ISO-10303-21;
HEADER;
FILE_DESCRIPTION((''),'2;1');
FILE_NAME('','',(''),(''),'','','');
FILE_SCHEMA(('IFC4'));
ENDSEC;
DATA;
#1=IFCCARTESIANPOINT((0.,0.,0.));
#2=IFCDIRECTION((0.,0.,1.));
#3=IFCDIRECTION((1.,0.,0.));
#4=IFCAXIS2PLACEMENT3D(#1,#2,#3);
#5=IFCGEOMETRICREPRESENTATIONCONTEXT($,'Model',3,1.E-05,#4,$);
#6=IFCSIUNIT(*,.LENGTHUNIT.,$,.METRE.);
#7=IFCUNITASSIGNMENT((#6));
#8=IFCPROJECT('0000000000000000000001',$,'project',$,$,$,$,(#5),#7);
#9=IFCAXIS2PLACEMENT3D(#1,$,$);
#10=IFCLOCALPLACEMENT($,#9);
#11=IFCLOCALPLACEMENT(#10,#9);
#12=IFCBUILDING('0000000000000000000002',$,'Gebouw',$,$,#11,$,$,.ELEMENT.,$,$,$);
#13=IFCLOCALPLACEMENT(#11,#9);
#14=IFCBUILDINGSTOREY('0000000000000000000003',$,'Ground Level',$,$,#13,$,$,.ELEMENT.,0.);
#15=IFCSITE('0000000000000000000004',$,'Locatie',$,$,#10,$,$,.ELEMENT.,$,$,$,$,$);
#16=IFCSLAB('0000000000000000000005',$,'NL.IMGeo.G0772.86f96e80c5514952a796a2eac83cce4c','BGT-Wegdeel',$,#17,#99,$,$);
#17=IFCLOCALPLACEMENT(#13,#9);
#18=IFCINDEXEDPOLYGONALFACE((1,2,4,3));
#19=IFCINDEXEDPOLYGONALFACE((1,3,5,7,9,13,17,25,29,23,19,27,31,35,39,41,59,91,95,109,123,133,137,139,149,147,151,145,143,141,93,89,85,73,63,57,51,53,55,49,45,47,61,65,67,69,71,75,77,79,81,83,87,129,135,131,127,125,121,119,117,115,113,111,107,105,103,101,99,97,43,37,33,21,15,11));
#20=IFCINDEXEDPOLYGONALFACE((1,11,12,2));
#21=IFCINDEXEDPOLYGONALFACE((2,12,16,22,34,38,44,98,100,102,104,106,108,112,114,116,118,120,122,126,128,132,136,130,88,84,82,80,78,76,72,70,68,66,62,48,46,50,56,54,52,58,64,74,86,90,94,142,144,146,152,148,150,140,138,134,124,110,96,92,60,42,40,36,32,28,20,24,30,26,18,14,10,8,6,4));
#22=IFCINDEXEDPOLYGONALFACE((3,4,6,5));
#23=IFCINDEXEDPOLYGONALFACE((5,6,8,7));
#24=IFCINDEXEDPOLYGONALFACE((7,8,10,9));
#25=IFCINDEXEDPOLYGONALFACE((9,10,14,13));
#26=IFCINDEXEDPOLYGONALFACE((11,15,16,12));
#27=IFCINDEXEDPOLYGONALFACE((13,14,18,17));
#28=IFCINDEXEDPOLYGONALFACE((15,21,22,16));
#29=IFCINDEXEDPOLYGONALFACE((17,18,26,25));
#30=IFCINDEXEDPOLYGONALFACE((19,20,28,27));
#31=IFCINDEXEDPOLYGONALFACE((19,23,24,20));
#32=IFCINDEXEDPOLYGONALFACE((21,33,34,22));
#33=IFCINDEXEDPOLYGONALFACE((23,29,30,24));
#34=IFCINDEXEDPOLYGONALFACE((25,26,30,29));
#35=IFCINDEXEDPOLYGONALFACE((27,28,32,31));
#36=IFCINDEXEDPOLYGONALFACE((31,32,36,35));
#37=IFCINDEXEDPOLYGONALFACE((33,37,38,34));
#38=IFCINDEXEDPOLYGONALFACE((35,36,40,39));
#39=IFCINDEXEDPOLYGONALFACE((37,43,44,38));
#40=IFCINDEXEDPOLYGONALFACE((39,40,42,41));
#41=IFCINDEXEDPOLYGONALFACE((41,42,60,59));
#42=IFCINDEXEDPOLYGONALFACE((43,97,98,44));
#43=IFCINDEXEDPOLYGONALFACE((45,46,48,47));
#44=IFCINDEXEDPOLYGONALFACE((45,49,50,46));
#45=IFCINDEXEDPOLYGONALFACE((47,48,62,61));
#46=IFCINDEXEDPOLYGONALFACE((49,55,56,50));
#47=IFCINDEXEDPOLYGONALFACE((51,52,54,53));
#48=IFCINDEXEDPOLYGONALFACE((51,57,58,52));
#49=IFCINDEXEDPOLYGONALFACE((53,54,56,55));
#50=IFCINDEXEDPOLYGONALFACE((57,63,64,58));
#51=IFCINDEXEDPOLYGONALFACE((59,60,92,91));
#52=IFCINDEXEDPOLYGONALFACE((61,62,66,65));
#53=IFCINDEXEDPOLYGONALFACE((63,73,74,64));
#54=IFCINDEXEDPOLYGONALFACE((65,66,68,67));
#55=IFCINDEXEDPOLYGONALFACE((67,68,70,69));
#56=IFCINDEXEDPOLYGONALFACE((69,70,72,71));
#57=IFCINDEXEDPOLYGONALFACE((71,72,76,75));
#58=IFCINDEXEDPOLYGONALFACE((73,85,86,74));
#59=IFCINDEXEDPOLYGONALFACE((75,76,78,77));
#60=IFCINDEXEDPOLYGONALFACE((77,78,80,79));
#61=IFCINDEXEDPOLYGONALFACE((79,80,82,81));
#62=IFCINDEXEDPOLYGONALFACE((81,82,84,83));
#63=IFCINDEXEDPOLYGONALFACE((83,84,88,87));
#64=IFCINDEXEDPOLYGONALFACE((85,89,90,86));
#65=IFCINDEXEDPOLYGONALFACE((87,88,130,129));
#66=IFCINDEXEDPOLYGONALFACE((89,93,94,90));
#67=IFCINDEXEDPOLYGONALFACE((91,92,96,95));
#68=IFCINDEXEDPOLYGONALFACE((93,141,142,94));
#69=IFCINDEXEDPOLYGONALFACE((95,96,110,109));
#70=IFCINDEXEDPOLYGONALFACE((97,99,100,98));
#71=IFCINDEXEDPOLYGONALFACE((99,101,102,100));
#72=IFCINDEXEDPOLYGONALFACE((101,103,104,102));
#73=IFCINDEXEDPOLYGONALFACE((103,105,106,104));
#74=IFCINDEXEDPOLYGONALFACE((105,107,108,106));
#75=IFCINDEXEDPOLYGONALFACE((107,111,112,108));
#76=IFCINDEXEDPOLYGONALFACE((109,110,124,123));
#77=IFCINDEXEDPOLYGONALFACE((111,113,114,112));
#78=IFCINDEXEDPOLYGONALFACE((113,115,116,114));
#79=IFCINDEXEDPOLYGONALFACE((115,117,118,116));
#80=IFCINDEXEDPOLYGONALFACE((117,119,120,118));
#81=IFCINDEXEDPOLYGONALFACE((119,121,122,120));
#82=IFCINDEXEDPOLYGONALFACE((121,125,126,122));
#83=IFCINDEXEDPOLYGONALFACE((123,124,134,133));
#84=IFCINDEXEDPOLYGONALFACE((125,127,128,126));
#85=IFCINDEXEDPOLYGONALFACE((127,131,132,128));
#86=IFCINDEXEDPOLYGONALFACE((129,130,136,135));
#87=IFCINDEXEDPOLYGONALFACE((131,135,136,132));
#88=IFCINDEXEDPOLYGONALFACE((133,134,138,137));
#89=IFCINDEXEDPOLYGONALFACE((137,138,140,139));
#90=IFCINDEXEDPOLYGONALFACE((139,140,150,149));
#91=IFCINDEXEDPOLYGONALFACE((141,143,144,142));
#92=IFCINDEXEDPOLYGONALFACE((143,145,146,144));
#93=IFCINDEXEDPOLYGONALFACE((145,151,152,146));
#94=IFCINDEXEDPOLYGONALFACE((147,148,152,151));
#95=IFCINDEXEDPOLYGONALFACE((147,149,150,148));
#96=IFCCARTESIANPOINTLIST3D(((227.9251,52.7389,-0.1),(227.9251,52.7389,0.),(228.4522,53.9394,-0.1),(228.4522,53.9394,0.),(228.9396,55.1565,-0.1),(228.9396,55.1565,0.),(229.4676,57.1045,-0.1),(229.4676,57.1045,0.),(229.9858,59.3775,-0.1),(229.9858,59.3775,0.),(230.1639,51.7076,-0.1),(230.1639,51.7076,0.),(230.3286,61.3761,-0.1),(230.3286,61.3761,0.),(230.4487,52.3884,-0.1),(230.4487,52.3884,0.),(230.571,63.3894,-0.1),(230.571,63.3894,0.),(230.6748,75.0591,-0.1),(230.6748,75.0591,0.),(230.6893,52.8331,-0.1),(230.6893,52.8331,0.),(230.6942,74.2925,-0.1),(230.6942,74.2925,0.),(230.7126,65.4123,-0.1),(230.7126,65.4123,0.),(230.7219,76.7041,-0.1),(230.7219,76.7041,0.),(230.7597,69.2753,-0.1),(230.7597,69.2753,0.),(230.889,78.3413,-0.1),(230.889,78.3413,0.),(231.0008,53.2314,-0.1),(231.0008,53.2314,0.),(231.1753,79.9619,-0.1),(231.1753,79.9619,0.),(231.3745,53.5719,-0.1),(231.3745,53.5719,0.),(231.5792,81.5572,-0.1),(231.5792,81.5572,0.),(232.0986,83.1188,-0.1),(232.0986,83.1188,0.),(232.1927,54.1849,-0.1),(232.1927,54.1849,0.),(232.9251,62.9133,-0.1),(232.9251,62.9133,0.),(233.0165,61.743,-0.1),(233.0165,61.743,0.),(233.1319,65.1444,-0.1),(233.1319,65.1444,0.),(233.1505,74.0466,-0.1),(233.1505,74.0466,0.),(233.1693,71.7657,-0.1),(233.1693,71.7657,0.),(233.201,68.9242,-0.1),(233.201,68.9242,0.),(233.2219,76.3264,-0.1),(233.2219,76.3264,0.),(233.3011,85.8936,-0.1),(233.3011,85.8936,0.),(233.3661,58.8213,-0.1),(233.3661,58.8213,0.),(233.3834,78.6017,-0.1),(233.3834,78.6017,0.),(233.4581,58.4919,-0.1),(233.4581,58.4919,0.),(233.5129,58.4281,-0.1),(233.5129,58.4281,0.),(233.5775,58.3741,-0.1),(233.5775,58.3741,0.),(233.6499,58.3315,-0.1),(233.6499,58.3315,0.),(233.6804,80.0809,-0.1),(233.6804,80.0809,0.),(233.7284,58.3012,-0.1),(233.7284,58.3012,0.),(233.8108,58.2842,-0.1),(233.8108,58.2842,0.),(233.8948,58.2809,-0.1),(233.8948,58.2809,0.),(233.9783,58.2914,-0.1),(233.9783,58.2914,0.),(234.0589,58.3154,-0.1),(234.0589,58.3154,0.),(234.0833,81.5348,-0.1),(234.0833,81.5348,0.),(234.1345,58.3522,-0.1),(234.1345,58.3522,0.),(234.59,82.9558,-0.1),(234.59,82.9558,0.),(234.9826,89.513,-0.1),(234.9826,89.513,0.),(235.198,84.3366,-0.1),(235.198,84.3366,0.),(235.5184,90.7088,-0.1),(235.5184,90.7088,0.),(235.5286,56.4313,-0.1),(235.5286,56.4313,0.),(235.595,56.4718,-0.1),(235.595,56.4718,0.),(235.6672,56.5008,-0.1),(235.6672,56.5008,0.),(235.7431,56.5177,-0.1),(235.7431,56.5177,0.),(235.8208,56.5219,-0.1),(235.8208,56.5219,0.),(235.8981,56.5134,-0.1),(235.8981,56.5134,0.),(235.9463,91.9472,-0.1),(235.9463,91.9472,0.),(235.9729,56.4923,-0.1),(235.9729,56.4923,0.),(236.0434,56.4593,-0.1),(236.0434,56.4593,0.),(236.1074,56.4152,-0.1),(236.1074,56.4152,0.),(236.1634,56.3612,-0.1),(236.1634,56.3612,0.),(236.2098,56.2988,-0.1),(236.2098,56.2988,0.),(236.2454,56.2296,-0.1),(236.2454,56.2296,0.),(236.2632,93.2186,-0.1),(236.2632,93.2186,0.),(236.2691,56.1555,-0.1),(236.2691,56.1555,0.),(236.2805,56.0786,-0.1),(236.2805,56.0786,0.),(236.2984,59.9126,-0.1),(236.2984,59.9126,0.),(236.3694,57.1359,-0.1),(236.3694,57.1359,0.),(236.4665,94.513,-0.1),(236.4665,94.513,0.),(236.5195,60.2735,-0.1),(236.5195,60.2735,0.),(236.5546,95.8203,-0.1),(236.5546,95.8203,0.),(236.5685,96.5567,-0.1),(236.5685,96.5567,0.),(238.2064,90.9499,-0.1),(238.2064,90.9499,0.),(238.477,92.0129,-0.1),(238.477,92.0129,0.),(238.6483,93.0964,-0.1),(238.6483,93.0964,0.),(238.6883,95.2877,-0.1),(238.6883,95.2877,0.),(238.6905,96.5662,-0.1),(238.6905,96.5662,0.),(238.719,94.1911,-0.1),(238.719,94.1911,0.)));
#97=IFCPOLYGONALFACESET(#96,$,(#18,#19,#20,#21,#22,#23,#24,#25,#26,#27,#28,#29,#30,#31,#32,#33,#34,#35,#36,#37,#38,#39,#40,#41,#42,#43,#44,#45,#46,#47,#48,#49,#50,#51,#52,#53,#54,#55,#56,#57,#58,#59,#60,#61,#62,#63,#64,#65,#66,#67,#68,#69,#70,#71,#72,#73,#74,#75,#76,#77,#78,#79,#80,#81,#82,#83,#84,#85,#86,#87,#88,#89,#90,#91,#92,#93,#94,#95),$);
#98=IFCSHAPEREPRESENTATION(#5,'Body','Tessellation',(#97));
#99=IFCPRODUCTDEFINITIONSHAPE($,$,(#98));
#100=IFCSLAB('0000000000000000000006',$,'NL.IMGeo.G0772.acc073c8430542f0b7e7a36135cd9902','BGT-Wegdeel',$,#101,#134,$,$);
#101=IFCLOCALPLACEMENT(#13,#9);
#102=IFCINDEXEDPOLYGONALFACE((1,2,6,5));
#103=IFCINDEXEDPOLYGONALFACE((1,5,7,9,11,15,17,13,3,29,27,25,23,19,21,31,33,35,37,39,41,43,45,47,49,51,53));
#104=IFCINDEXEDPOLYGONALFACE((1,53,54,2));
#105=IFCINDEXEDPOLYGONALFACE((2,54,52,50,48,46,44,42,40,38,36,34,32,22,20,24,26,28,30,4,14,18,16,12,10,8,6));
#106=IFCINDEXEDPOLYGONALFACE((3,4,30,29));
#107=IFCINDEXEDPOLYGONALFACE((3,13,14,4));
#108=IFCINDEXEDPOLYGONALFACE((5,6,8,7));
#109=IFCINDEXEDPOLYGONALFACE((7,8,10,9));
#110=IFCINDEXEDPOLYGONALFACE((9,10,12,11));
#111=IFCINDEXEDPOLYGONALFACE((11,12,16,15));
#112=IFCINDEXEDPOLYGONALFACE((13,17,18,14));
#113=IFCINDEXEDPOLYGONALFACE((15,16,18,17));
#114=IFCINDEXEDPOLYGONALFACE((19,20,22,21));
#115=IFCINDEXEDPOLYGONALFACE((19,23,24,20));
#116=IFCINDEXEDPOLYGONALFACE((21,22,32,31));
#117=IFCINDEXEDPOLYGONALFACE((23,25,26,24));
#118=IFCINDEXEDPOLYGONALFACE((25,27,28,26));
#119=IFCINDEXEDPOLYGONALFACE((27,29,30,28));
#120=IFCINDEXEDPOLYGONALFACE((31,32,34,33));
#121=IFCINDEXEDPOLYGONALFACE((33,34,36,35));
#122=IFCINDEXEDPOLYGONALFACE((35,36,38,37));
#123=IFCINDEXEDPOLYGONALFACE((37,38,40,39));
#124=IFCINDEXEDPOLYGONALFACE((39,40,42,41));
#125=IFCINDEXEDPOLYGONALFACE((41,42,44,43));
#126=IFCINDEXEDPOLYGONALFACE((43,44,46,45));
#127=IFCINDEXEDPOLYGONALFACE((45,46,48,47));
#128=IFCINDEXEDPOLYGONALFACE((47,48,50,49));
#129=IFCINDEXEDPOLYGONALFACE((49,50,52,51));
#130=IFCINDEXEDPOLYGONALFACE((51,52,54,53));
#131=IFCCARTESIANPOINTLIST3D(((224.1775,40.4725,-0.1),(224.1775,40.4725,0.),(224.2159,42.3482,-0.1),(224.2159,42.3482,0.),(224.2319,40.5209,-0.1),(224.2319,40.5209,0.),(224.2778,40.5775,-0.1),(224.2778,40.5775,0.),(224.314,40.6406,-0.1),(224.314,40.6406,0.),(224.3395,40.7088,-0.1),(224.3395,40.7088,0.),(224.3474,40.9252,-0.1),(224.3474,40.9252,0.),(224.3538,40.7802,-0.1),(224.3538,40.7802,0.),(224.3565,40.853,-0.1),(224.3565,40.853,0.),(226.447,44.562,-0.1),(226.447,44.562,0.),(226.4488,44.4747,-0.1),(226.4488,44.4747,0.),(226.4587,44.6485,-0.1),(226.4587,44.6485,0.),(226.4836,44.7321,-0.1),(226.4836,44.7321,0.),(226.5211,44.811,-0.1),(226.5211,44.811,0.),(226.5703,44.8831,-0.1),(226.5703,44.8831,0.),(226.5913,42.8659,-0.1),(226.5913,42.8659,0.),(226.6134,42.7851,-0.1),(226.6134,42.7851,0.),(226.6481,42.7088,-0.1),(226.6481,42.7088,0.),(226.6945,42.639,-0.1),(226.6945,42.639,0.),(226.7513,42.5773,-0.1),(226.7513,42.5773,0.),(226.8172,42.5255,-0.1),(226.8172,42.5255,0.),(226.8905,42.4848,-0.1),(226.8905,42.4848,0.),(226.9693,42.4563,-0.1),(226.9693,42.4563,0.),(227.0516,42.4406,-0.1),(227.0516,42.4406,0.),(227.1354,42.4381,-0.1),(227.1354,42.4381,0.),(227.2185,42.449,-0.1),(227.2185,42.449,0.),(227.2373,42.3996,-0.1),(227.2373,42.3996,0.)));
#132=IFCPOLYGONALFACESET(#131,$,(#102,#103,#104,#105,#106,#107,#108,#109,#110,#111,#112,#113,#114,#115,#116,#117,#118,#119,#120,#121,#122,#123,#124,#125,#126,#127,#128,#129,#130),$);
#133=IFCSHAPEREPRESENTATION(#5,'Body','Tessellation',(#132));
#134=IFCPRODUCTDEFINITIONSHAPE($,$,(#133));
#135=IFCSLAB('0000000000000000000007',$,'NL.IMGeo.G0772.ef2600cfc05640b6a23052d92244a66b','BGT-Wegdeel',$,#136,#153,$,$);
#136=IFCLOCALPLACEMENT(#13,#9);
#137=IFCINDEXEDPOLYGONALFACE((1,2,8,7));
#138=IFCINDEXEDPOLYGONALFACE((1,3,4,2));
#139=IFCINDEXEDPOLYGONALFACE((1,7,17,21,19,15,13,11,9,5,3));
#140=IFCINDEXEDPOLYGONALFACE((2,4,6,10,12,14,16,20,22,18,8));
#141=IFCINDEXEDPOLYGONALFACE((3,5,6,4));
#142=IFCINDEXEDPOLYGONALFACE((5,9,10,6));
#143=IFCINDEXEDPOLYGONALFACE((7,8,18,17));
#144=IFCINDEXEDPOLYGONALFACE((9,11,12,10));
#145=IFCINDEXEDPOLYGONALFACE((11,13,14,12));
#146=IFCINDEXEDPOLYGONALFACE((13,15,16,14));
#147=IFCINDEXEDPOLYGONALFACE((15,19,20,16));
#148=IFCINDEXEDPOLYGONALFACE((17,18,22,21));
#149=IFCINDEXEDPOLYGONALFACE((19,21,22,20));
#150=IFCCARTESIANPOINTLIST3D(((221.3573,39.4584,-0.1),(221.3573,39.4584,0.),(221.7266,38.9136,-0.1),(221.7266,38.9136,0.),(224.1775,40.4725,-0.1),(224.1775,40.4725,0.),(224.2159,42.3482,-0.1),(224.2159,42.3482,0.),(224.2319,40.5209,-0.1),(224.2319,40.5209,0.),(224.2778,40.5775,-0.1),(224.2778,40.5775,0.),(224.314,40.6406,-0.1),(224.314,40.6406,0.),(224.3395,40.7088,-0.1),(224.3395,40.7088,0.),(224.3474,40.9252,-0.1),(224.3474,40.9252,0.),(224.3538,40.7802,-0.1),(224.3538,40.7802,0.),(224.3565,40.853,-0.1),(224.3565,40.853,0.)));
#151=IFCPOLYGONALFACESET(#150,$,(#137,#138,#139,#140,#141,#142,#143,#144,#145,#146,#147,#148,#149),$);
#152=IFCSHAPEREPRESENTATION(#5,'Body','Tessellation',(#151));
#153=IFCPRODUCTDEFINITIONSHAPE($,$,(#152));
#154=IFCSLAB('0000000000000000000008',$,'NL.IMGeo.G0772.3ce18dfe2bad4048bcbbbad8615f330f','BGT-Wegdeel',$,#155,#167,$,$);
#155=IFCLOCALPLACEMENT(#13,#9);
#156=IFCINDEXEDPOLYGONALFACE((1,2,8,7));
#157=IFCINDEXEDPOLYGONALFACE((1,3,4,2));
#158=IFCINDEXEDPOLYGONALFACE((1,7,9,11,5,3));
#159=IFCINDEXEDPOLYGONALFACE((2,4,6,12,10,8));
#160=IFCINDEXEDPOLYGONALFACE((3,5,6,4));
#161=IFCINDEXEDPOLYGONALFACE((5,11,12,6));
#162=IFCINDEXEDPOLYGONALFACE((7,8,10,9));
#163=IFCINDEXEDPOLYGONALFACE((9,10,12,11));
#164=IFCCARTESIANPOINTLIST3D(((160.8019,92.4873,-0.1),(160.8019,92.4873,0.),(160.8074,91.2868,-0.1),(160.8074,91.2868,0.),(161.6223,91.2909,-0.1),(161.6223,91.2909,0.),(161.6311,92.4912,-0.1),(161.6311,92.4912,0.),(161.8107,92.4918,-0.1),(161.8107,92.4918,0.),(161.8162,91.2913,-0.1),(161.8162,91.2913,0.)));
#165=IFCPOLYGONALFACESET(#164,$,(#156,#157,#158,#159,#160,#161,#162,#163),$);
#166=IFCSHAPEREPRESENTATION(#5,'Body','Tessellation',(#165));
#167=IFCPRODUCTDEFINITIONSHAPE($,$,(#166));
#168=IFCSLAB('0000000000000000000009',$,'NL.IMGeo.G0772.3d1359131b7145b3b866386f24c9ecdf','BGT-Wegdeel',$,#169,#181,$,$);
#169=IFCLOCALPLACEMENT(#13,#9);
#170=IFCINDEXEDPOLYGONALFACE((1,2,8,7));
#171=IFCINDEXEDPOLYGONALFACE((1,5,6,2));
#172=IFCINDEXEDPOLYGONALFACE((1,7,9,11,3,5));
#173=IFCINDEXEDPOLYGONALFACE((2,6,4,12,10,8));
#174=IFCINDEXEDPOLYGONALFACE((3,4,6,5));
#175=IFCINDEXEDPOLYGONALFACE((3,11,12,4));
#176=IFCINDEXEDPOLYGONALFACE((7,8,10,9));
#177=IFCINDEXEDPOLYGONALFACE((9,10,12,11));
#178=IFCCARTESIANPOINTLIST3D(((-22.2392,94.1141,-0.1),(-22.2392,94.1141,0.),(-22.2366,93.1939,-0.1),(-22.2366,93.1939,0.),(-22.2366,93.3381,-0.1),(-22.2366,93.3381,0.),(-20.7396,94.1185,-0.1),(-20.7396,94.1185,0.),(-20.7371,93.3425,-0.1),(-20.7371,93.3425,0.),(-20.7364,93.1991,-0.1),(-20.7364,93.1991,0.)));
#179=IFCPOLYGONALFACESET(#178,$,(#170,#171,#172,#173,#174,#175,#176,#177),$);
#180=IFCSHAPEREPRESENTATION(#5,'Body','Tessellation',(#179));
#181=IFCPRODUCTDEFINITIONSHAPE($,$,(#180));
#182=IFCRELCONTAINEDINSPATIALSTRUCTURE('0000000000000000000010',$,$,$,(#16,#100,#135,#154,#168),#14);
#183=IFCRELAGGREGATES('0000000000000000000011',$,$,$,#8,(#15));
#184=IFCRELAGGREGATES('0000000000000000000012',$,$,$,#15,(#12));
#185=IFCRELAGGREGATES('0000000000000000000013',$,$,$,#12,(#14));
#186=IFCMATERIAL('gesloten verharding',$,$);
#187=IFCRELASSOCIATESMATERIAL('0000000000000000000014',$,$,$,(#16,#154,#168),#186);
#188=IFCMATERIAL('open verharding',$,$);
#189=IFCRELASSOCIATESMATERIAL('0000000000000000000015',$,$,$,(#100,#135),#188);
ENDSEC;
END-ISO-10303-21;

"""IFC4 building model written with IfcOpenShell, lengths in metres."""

from ifc_helpers import new_model, si_unit, frame, origin, origin_with_axes, place, context, project, spatial, polyline, outline, extrude, material, element, save


model = new_model("IFC4")

# Units and contexts
model_context = context("Model", 3, precision=1e-05, world=origin_with_axes())
ifc_project = project(units=[si_unit("LENGTHUNIT", "METRE")], contexts=[model_context])

# Site, building, storey
site_placement = place(None, origin())
site = spatial("IfcSite", under=ifc_project, at=site_placement, Name="Locatie", CompositionType="ELEMENT")
building_placement = place(site_placement, origin())
building = spatial("IfcBuilding", under=site, at=building_placement, Name="Gebouw", CompositionType="ELEMENT")
storey_placement = place(building_placement, origin())
storey = spatial("IfcBuildingStorey", under=building, at=storey_placement, Name="Ground Level", CompositionType="ELEMENT", Elevation=0.0)

# Slabs
ifc_material_1 = material(Name="open verharding")
ifc_material_2 = material(Name="gesloten verharding")
slab_1_placement = place(storey_placement, origin())
element("IfcSlab", 1, at=slab_1_placement, inside=storey, material=ifc_material_2, Name="NL.IMGeo.G0772.86f96e80c5514952a796a2eac83cce4c", Description="BGT-Wegdeel", context=model_context, shape_type="SweptSolid", body=[
    extrude(outline(polyline([(233.3661, 58.8213), (233.4581, 58.4919), (233.5129, 58.4281), (233.5775, 58.3741), (233.6499, 58.3315), (233.7284, 58.3012), (233.8108, 58.2842), (233.8948, 58.2809), (233.9783, 58.2914), (234.0589, 58.3154), (234.1345, 58.3522), (236.2984, 59.9126), (236.5195, 60.2735), (236.3694, 57.1359), (236.2805, 56.0786), (236.2691, 56.1555), (236.2454, 56.2296), (236.2098, 56.2988), (236.1634, 56.3612), (236.1074, 56.4152), (236.0434, 56.4593), (235.9729, 56.4923), (235.8981, 56.5134), (235.8208, 56.5219), (235.7431, 56.5177), (235.6672, 56.5008), (235.595, 56.4718), (235.5286, 56.4313), (232.1927, 54.1849), (231.3745, 53.5719), (231.0008, 53.2314), (230.6893, 52.8331), (230.4487, 52.3884), (230.1639, 51.7076), (227.9251, 52.7389), (228.4522, 53.9394), (228.9396, 55.1565), (229.4676, 57.1045), (229.9858, 59.3775), (230.3286, 61.3761), (230.571, 63.3894), (230.7126, 65.4123), (230.7597, 69.2753), (230.6942, 74.2925), (230.6748, 75.0591), (230.7219, 76.7041), (230.889, 78.3413), (231.1753, 79.9619), (231.5792, 81.5572), (232.0986, 83.1188), (233.3011, 85.8936), (234.9826, 89.513), (235.5184, 90.7088), (235.9463, 91.9472), (236.2632, 93.2186), (236.4665, 94.513), (236.5546, 95.8203), (236.5685, 96.5567), (238.6905, 96.5662), (238.6883, 95.2877), (238.719, 94.1911), (238.6483, 93.0964), (238.477, 92.0129), (238.2064, 90.9499), (235.198, 84.3366), (234.59, 82.9558), (234.0833, 81.5348), (233.6804, 80.0809), (233.3834, 78.6017), (233.2219, 76.3264), (233.1505, 74.0466), (233.1693, 71.7657), (233.201, 68.9242), (233.1319, 65.1444), (232.9251, 62.9133), (233.0165, 61.743), (233.3661, 58.8213)])), frame((0.0, 0.0, -0.1), z_axis=(0.0, 0.0, 1.0), x_axis=(1.0, 0.0, 0.0)), (0.0, 0.0, 1.0), 0.1),
])
slab_2_placement = place(storey_placement, origin())
element("IfcSlab", 2, at=slab_2_placement, inside=storey, material=ifc_material_1, Name="NL.IMGeo.G0772.acc073c8430542f0b7e7a36135cd9902", Description="BGT-Wegdeel", context=model_context, shape_type="SweptSolid", body=[
    extrude(outline(polyline([(226.5211, 44.811), (226.4836, 44.7321), (226.4587, 44.6485), (226.447, 44.562), (226.4488, 44.4747), (226.5913, 42.8659), (226.6134, 42.7851), (226.6481, 42.7088), (226.6945, 42.639), (226.7513, 42.5773), (226.8172, 42.5255), (226.8905, 42.4848), (226.9693, 42.4563), (227.0516, 42.4406), (227.1354, 42.4381), (227.2185, 42.449), (227.2373, 42.3996), (224.1775, 40.4725), (224.2319, 40.5209), (224.2778, 40.5775), (224.314, 40.6406), (224.3395, 40.7088), (224.3538, 40.7802), (224.3565, 40.853), (224.3474, 40.9252), (224.2159, 42.3482), (226.5703, 44.8831), (226.5211, 44.811)])), frame((0.0, 0.0, -0.1), z_axis=(0.0, 0.0, 1.0), x_axis=(1.0, 0.0, 0.0)), (0.0, 0.0, 1.0), 0.1),
])
slab_3_placement = place(storey_placement, origin())
element("IfcSlab", 3, at=slab_3_placement, inside=storey, material=ifc_material_1, Name="NL.IMGeo.G0772.ef2600cfc05640b6a23052d92244a66b", Description="BGT-Wegdeel", context=model_context, shape_type="SweptSolid", body=[
    extrude(outline(polyline([(224.3474, 40.9252), (224.3565, 40.853), (224.3538, 40.7802), (224.3395, 40.7088), (224.314, 40.6406), (224.2778, 40.5775), (224.2319, 40.5209), (224.1775, 40.4725), (221.7266, 38.9136), (221.3573, 39.4584), (224.2159, 42.3482), (224.3474, 40.9252)])), frame((0.0, 0.0, -0.1), z_axis=(0.0, 0.0, 1.0), x_axis=(1.0, 0.0, 0.0)), (0.0, 0.0, 1.0), 0.1),
])
slab_4_placement = place(storey_placement, origin())
element("IfcSlab", 4, at=slab_4_placement, inside=storey, material=ifc_material_2, Name="NL.IMGeo.G0772.3ce18dfe2bad4048bcbbbad8615f330f", Description="BGT-Wegdeel", context=model_context, shape_type="SweptSolid", body=[
    extrude(outline(polyline([(161.6311, 92.4912), (161.8107, 92.4918), (161.8162, 91.2913), (161.6223, 91.2909), (160.8074, 91.2868), (160.8019, 92.4873), (161.6311, 92.4912)])), frame((0.0, 0.0, -0.1), z_axis=(0.0, 0.0, 1.0), x_axis=(1.0, 0.0, 0.0)), (0.0, 0.0, 1.0), 0.1),
])
slab_5_placement = place(storey_placement, origin())
element("IfcSlab", 5, at=slab_5_placement, inside=storey, material=ifc_material_2, Name="NL.IMGeo.G0772.3d1359131b7145b3b866386f24c9ecdf", Description="BGT-Wegdeel", context=model_context, shape_type="SweptSolid", body=[
    extrude(outline(polyline([(-22.2366, 93.3381), (-22.2392, 94.1141), (-20.7396, 94.1185), (-20.7371, 93.3425), (-20.7364, 93.1991), (-22.2366, 93.1939), (-22.2366, 93.3381)])), frame((0.0, 0.0, -0.1), z_axis=(0.0, 0.0, 1.0), x_axis=(1.0, 0.0, 0.0)), (0.0, 0.0, 1.0), 0.1),
])

save(model, "model.ifc")
